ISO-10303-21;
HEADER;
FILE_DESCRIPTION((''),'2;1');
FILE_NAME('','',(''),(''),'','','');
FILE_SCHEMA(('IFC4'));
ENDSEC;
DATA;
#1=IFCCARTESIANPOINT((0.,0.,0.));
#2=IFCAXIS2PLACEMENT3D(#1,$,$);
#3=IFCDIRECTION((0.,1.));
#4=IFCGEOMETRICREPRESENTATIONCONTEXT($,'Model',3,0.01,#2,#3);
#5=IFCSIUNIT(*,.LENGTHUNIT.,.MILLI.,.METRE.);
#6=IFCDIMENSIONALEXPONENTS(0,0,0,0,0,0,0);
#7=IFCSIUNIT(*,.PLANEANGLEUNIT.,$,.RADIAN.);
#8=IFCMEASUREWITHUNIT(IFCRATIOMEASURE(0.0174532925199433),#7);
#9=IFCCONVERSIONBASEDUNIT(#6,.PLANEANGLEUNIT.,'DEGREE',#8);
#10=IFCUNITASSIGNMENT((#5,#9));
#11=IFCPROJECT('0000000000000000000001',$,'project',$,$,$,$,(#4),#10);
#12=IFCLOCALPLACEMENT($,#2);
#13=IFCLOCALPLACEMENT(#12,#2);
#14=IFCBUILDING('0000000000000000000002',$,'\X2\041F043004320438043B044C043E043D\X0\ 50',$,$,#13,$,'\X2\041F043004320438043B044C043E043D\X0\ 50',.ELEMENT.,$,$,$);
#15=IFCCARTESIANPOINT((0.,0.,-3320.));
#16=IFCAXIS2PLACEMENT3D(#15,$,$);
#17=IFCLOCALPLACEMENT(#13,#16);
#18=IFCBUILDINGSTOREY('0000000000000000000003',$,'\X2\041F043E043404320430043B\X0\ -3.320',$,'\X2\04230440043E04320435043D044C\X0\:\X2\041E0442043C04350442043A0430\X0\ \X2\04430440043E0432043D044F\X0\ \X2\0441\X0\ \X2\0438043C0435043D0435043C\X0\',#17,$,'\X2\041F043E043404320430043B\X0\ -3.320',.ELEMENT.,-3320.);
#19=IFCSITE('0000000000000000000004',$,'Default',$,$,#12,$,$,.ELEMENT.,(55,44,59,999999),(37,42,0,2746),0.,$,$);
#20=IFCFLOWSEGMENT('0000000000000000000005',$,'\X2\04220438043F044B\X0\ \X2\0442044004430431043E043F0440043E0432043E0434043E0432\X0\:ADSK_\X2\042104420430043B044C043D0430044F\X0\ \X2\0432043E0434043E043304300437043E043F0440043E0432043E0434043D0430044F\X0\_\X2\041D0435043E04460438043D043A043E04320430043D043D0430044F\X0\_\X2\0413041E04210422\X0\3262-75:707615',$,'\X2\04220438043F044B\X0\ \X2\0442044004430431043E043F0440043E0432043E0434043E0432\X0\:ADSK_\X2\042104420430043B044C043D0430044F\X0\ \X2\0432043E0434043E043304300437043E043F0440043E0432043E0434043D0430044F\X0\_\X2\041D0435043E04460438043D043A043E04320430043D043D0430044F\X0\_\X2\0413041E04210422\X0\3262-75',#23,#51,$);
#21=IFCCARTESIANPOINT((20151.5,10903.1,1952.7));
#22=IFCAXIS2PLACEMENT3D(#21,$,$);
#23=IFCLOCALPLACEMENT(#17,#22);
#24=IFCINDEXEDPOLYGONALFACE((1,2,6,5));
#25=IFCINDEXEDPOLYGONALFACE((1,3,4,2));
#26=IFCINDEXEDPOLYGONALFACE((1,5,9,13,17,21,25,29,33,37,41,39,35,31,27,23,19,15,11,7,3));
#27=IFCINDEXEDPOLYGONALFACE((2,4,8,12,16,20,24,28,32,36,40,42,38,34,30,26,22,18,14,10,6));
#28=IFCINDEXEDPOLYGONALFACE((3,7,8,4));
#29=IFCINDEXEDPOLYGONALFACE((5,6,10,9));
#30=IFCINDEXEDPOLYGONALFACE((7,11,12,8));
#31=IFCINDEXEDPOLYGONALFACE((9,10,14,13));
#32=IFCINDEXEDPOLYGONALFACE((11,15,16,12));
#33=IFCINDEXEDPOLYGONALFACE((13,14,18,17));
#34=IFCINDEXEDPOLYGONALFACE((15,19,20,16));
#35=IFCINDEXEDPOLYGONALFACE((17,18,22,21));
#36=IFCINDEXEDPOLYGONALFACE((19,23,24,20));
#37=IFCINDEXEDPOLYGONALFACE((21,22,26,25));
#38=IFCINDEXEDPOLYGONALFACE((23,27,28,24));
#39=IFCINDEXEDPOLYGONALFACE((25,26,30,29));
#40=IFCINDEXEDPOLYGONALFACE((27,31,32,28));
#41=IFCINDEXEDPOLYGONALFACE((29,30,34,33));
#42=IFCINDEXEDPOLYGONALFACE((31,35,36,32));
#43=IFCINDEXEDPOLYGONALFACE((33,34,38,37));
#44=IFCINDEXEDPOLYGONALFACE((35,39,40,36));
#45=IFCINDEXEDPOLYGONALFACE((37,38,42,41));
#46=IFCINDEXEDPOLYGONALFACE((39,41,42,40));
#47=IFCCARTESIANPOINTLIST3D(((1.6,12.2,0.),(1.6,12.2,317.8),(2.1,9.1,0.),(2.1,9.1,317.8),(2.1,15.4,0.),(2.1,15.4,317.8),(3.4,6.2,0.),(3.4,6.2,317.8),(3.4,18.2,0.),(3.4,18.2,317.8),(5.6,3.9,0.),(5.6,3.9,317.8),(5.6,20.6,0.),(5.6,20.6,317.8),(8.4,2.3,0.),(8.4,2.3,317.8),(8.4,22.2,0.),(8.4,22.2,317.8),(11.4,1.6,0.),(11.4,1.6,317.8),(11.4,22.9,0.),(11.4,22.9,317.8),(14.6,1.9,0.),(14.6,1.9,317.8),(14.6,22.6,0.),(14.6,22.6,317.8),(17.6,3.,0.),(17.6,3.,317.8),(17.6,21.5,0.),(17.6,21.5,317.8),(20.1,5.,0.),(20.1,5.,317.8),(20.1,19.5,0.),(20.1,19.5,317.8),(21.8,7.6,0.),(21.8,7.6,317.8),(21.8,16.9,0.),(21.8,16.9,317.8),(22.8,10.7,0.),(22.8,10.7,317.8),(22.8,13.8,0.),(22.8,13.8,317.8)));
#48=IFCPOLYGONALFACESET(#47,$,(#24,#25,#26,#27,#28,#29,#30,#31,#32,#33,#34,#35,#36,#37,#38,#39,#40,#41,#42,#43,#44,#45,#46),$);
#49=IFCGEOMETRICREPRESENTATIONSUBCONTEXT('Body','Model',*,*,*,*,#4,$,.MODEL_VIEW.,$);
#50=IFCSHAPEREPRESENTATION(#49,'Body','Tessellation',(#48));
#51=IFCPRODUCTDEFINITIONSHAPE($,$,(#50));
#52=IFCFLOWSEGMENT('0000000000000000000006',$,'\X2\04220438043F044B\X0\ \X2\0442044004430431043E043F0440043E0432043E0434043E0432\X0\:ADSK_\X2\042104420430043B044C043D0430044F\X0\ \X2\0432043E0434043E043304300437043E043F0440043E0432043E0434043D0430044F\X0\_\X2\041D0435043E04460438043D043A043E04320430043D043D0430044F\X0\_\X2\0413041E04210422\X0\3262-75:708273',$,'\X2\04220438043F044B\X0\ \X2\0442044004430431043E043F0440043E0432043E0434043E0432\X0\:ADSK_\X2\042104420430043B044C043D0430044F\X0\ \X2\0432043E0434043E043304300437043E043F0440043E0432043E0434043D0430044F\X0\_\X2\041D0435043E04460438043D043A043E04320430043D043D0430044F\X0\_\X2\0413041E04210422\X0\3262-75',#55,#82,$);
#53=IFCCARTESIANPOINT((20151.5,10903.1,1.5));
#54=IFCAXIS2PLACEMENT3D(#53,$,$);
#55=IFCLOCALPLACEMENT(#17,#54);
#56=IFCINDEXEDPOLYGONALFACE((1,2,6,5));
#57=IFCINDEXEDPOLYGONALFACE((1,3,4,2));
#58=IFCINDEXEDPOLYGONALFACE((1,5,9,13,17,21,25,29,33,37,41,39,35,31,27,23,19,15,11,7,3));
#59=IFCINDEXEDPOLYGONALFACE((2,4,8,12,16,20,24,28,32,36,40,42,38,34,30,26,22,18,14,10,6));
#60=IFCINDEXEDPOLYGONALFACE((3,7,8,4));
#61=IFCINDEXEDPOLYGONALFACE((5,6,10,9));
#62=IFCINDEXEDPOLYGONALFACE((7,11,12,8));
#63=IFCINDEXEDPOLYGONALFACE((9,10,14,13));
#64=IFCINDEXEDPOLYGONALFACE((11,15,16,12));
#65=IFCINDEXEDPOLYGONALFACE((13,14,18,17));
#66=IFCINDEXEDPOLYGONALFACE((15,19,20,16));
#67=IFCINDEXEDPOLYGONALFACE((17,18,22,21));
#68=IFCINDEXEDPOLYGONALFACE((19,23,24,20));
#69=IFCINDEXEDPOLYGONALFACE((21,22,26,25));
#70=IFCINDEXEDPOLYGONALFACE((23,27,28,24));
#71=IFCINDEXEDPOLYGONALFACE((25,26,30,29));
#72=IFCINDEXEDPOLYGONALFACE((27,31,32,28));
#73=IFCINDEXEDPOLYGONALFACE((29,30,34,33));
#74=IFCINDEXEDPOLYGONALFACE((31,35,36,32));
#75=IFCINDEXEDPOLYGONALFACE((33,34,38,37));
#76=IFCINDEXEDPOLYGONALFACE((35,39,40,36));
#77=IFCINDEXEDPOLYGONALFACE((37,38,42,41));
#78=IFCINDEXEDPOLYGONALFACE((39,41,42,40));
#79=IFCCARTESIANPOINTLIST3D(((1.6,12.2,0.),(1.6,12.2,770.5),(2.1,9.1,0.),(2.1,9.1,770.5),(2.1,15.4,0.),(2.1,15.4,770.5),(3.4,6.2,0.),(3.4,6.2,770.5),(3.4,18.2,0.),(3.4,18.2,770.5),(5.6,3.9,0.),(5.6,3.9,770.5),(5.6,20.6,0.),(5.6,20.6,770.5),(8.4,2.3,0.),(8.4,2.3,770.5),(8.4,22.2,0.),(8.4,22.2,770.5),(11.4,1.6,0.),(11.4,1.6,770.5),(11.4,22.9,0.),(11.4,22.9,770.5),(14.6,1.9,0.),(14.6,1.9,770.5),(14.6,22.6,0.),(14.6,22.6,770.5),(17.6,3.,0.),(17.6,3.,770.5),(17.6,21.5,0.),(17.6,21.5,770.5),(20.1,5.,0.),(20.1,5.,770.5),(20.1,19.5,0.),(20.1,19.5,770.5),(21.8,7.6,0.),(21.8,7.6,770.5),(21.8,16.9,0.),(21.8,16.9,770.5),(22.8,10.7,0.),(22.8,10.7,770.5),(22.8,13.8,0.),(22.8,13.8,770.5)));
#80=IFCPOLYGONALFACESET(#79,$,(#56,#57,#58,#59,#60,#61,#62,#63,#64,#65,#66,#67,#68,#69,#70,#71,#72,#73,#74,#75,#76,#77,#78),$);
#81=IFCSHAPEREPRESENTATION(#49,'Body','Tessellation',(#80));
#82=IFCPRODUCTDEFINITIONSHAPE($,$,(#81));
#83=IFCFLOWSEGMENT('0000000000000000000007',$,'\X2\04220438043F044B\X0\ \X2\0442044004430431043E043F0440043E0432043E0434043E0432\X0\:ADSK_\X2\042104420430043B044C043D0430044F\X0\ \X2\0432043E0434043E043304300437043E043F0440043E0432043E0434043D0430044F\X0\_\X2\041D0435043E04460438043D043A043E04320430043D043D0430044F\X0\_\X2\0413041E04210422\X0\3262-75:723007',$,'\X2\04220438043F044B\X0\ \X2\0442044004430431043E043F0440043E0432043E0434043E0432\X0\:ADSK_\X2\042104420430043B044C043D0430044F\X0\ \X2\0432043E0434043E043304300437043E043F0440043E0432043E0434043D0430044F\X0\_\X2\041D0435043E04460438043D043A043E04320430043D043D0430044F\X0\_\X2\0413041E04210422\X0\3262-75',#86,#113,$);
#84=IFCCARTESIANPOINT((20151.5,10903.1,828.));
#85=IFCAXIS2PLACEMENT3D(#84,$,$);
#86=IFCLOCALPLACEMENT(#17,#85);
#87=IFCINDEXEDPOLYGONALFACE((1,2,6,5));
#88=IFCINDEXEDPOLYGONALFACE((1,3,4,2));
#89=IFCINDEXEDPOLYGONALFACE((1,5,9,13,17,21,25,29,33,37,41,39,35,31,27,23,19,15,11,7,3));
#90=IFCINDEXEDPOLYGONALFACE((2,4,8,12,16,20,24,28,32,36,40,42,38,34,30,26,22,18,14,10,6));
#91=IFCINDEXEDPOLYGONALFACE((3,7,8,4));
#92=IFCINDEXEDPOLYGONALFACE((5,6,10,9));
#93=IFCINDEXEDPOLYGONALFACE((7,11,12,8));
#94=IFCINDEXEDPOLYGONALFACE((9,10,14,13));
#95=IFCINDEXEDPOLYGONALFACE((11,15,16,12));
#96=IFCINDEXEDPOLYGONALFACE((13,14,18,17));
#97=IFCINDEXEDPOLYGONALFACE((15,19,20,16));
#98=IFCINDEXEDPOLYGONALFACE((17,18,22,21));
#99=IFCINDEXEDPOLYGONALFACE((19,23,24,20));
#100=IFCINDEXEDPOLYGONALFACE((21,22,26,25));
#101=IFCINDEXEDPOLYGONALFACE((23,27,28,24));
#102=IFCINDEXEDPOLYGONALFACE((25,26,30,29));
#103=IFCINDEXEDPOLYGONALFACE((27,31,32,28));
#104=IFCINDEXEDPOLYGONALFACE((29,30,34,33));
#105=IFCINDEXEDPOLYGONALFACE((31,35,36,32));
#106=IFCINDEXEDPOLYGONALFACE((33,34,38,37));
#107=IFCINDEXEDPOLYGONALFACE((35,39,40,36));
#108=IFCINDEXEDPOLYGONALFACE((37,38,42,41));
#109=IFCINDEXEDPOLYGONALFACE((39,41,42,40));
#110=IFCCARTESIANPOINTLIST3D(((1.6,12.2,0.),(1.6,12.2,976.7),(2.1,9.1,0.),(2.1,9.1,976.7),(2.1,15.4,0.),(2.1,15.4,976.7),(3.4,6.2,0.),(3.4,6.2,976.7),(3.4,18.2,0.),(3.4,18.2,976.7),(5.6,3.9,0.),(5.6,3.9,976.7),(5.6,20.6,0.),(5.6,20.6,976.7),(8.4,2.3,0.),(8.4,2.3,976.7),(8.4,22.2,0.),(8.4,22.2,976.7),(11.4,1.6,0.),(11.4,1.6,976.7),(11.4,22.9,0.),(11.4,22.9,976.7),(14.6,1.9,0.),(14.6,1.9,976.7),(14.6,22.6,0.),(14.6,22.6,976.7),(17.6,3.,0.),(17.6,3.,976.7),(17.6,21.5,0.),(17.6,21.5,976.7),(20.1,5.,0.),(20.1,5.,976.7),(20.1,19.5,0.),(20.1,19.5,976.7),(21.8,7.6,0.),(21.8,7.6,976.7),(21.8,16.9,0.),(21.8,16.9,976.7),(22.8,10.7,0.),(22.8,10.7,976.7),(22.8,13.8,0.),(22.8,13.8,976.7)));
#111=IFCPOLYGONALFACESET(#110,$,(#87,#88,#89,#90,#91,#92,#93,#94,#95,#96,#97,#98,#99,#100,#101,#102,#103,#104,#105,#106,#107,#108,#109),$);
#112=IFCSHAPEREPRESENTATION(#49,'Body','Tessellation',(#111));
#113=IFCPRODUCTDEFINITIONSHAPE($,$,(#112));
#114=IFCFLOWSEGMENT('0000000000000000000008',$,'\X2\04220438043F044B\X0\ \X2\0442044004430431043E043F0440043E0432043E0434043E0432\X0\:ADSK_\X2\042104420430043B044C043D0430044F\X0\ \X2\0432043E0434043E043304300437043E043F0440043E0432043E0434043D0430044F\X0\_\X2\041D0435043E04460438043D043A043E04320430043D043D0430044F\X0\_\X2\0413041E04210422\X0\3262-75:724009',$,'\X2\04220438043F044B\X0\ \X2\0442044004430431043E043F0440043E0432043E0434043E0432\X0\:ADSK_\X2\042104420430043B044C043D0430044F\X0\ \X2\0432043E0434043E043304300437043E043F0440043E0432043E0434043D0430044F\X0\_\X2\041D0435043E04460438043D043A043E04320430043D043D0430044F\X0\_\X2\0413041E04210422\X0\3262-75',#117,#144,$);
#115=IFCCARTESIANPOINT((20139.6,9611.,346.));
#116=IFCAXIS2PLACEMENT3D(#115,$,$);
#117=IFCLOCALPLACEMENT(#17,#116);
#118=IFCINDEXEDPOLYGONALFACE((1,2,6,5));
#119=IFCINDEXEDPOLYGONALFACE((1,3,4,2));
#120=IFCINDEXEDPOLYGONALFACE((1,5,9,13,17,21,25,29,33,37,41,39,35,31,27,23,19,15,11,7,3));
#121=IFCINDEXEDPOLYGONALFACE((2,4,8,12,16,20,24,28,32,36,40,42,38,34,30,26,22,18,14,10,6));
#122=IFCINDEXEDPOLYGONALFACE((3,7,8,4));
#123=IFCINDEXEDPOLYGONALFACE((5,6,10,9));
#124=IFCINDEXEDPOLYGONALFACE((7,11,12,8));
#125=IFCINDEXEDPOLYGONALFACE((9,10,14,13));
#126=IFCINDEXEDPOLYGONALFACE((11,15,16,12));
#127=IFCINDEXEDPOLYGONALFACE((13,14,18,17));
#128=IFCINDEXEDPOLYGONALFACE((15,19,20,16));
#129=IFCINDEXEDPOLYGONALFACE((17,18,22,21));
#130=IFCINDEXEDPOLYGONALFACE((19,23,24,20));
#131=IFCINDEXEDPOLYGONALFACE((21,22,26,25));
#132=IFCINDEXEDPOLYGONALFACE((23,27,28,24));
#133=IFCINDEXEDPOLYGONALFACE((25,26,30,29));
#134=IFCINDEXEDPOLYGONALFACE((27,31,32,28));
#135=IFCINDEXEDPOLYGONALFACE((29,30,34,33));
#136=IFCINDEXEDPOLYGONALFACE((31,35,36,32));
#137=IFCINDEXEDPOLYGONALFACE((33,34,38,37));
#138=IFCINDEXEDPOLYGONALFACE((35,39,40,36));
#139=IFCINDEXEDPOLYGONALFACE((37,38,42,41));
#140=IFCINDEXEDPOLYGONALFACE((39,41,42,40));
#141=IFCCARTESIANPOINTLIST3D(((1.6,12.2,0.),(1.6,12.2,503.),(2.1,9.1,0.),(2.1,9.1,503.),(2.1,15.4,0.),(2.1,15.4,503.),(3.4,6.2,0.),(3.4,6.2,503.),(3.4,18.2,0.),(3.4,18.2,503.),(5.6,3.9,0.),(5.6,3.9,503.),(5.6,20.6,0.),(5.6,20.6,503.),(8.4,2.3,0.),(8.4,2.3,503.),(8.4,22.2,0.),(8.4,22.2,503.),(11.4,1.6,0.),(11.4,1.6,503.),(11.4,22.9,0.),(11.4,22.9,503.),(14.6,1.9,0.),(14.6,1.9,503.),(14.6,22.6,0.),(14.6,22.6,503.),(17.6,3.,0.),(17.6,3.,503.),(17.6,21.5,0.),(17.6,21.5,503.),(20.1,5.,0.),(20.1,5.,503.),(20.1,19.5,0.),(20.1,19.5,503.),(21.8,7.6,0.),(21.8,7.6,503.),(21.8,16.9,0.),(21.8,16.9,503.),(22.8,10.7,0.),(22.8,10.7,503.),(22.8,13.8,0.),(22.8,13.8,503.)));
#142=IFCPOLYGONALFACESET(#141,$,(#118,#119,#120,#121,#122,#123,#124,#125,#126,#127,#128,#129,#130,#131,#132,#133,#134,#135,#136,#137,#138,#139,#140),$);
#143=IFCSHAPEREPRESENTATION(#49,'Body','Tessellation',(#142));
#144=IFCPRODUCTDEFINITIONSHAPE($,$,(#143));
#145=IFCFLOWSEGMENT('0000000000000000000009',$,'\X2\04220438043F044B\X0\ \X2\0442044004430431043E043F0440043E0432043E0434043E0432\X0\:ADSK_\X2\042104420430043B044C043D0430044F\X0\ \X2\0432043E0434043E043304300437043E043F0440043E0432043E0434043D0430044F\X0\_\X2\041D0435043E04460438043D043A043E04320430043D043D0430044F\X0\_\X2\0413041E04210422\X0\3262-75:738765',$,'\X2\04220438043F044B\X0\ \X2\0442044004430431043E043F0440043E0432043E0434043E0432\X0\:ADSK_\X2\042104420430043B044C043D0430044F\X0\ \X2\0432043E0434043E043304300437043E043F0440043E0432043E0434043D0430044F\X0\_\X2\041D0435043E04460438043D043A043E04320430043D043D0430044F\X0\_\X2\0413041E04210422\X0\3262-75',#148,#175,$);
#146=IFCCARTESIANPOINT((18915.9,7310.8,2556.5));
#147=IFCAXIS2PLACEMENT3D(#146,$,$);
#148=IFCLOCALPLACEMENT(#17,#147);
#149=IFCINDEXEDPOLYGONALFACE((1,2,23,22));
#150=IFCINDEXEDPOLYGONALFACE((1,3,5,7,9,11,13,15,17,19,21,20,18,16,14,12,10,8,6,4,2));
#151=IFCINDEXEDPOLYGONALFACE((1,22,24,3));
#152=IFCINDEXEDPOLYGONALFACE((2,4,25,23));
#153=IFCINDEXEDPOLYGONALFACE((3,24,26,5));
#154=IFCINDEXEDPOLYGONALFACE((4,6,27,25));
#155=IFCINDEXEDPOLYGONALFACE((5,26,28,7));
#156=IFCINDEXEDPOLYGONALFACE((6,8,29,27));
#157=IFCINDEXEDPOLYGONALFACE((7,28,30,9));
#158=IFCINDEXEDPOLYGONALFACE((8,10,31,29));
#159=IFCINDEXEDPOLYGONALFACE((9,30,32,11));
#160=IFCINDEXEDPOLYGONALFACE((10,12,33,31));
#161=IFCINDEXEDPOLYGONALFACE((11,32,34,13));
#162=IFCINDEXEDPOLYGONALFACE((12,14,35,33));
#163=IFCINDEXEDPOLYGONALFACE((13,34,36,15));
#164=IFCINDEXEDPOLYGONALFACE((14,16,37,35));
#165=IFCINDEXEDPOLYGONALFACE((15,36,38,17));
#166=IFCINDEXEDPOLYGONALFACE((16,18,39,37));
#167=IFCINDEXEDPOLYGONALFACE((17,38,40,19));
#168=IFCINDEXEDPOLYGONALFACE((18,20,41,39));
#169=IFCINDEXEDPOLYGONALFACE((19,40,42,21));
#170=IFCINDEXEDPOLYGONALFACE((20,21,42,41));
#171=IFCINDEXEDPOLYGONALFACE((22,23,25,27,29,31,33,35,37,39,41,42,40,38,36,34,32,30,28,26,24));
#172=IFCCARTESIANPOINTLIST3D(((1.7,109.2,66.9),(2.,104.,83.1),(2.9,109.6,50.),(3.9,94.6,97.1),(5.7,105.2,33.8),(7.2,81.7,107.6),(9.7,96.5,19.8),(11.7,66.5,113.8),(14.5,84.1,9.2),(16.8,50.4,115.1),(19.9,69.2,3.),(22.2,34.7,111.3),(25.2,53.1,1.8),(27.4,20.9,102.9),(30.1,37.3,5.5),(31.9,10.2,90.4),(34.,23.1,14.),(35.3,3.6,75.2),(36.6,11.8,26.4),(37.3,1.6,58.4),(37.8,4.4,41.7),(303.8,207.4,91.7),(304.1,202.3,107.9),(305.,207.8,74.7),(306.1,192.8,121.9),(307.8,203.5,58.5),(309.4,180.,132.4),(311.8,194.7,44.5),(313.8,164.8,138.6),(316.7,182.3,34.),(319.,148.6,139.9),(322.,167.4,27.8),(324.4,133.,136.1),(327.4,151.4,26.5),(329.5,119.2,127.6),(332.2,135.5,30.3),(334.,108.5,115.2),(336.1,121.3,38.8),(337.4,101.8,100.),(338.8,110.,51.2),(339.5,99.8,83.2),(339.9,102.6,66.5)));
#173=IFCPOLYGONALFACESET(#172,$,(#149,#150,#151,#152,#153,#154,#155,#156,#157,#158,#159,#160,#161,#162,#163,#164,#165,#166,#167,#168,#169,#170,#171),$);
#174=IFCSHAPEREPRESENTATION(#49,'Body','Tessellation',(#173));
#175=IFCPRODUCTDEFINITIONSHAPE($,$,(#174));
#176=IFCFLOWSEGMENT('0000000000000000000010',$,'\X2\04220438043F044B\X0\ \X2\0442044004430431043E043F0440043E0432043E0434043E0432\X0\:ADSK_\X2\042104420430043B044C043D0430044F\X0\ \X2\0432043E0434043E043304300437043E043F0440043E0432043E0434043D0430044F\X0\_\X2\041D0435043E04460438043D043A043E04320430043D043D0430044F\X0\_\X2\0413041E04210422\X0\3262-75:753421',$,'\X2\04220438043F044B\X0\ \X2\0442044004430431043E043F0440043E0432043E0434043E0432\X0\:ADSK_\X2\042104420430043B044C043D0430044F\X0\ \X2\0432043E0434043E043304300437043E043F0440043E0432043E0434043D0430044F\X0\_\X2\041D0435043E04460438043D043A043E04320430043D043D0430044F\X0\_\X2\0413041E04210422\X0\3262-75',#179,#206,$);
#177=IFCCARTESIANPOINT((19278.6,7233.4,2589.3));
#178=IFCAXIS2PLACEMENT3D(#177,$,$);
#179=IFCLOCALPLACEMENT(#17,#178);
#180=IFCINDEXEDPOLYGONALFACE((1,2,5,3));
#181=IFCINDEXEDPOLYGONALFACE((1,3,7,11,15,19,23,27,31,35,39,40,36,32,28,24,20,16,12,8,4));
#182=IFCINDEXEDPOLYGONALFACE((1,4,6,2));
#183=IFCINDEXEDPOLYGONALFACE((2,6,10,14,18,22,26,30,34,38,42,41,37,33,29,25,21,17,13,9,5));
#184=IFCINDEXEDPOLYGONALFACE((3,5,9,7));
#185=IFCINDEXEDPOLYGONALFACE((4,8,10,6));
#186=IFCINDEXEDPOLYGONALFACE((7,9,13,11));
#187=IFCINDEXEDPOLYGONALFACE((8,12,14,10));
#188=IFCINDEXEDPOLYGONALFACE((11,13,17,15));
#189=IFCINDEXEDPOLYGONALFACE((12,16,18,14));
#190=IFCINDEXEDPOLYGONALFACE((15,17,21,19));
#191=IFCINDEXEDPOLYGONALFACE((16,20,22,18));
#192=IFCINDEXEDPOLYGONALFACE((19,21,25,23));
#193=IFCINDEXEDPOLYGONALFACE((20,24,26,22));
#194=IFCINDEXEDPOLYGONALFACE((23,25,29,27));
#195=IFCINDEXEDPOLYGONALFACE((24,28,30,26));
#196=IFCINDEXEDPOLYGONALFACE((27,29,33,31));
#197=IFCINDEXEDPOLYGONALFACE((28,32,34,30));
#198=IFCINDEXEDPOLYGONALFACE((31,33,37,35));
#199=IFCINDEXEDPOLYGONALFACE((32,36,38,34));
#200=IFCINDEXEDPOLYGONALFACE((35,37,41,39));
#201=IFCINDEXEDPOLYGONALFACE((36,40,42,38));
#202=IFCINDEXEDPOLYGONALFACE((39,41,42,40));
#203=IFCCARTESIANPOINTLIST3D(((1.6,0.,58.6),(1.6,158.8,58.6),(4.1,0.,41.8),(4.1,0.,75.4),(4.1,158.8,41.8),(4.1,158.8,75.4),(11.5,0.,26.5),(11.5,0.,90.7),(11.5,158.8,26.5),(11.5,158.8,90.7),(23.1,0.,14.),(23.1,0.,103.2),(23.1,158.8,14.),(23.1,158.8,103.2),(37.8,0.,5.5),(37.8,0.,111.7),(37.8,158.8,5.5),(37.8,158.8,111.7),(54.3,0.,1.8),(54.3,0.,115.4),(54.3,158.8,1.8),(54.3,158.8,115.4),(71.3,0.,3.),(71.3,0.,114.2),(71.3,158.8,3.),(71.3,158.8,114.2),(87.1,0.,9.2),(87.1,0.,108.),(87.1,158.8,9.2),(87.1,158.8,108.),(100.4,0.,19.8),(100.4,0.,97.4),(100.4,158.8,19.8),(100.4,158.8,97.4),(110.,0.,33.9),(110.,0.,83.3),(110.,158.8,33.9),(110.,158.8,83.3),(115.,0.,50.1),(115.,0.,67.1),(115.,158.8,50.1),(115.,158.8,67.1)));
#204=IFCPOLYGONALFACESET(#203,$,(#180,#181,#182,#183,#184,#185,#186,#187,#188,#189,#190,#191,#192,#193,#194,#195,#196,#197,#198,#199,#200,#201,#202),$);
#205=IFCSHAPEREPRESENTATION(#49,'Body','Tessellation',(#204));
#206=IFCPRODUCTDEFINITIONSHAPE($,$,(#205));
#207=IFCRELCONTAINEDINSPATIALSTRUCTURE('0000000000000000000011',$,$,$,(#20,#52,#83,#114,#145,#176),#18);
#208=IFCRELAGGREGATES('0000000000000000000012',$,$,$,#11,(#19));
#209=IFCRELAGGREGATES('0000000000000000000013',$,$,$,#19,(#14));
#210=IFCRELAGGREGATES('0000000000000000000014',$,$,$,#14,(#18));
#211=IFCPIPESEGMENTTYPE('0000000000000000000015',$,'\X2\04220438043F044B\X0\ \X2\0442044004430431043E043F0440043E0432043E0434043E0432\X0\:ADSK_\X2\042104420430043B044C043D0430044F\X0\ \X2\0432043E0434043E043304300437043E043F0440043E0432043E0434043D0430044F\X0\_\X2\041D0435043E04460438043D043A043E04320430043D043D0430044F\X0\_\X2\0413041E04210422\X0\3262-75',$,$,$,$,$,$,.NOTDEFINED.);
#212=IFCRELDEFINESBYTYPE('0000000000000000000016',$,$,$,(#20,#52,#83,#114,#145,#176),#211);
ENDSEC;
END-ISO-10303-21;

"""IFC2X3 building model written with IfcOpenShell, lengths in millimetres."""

from ifc_helpers import new_model, entity, si_unit, converted_unit, direction, frame, frame_2d, origin, origin_2d_with_axis, place, context, subcontext, project, spatial, circle, extrude, type_object, element, save


model = new_model("IFC2X3")

# Units and contexts
model_context = context("Model", 3, precision=0.01, world=origin(), true_north=direction((0.0, 1.0)))
body_context = subcontext(model_context, "Body", "Model", "MODEL_VIEW")
ifc_project = project(units=[si_unit("LENGTHUNIT", "METRE", prefix="MILLI"), converted_unit("PLANEANGLEUNIT", "DEGREE", entity("IfcRatioMeasure", 0.0174532925199433), si_unit("PLANEANGLEUNIT", "RADIAN"), dimensions=[0, 0, 0, 0, 0, 0, 0])], contexts=[model_context])

# Site, building, storey
site_placement = place(None, origin())
site = spatial("IfcSite", under=ifc_project, at=site_placement, Name="Default", CompositionType="ELEMENT", RefLatitude=(55, 44, 59, 999999), RefLongitude=(37, 42, 0, 2746), RefElevation=0.0)
building_placement = place(site_placement, origin())
building = spatial("IfcBuilding", under=site, at=building_placement, Name="Павильон 50", LongName="Павильон 50", CompositionType="ELEMENT")
storey_placement = place(building_placement, frame((0.0, 0.0, -3320.0)))
storey = spatial("IfcBuildingStorey", under=building, at=storey_placement, Name="Подвал -3.320", ObjectType="Уровень:Отметка уровня с именем", LongName="Подвал -3.320", CompositionType="ELEMENT", Elevation=-3320.0)

# Flow segments
pipe_segment_type = type_object("IfcPipeSegmentType", Name="Типы трубопроводов:ADSK_Стальная водогазопроводная_Неоцинкованная_ГОСТ3262-75", PredefinedType="NOTDEFINED")
flow_segment_1_placement = place(storey_placement, frame((20151.5, 10903.1, 1952.7)))
element("IfcFlowSegment", 1, at=flow_segment_1_placement, inside=storey, type_object=pipe_segment_type, Name="Типы трубопроводов:ADSK_Стальная водогазопроводная_Неоцинкованная_ГОСТ3262-75:707615", ObjectType="Типы трубопроводов:ADSK_Стальная водогазопроводная_Неоцинкованная_ГОСТ3262-75", context=body_context, shape_type="SweptSolid", body=[
    extrude(circle(Radius=10.7, at=origin_2d_with_axis()), frame((12.2, 12.2, 0.0), z_axis=(0.0, 0.0, 1.0), x_axis=(-1.0, 0.0, 0.0)), (0.0, 0.0, 1.0), 317.8),
])
flow_segment_2_placement = place(storey_placement, frame((20151.5, 10903.1, 1.5)))
element("IfcFlowSegment", 2, at=flow_segment_2_placement, inside=storey, type_object=pipe_segment_type, Name="Типы трубопроводов:ADSK_Стальная водогазопроводная_Неоцинкованная_ГОСТ3262-75:708273", ObjectType="Типы трубопроводов:ADSK_Стальная водогазопроводная_Неоцинкованная_ГОСТ3262-75", context=body_context, shape_type="SweptSolid", body=[
    extrude(circle(Radius=10.7, at=origin_2d_with_axis()), frame((12.2, 12.2, 0.0), z_axis=(0.0, 0.0, 1.0), x_axis=(-1.0, 0.0, 0.0)), (0.0, 0.0, 1.0), 770.5),
])
flow_segment_3_placement = place(storey_placement, frame((20151.5, 10903.1, 828.0)))
element("IfcFlowSegment", 3, at=flow_segment_3_placement, inside=storey, type_object=pipe_segment_type, Name="Типы трубопроводов:ADSK_Стальная водогазопроводная_Неоцинкованная_ГОСТ3262-75:723007", ObjectType="Типы трубопроводов:ADSK_Стальная водогазопроводная_Неоцинкованная_ГОСТ3262-75", context=body_context, shape_type="SweptSolid", body=[
    extrude(circle(Radius=10.7, at=origin_2d_with_axis()), frame((12.2, 12.2, 0.0), z_axis=(0.0, 0.0, 1.0), x_axis=(-1.0, 0.0, 0.0)), (0.0, 0.0, 1.0), 976.7),
])
flow_segment_4_placement = place(storey_placement, frame((20139.6, 9611.0, 346.0)))
element("IfcFlowSegment", 4, at=flow_segment_4_placement, inside=storey, type_object=pipe_segment_type, Name="Типы трубопроводов:ADSK_Стальная водогазопроводная_Неоцинкованная_ГОСТ3262-75:724009", ObjectType="Типы трубопроводов:ADSK_Стальная водогазопроводная_Неоцинкованная_ГОСТ3262-75", context=body_context, shape_type="SweptSolid", body=[
    extrude(circle(Radius=10.7, at=origin_2d_with_axis()), frame((12.2, 12.2, 0.0), z_axis=(0.0, 0.0, 1.0), x_axis=(-1.0, 0.0, 0.0)), (0.0, 0.0, 1.0), 503.0),
])
flow_segment_5_placement = place(storey_placement, frame((18915.9, 7310.8, 2556.5)))
element("IfcFlowSegment", 5, at=flow_segment_5_placement, inside=storey, type_object=pipe_segment_type, Name="Типы трубопроводов:ADSK_Стальная водогазопроводная_Неоцинкованная_ГОСТ3262-75:738765", ObjectType="Типы трубопроводов:ADSK_Стальная водогазопроводная_Неоцинкованная_ГОСТ3262-75", context=body_context, shape_type="SweptSolid", body=[
    extrude(circle(Radius=57.0, at=frame_2d((0.0, 0.0), x_axis=(1.0, 0.0))), frame((19.7, 55.8, 58.4), z_axis=(0.948111, 0.308285, 0.077758), x_axis=(0.309221, -0.95099, 0.0)), (0.0, 0.0, 1.0), 318.7),
])
flow_segment_6_placement = place(storey_placement, frame((19278.6, 7233.4, 2589.3)))
element("IfcFlowSegment", 6, at=flow_segment_6_placement, inside=storey, type_object=pipe_segment_type, Name="Типы трубопроводов:ADSK_Стальная водогазопроводная_Неоцинкованная_ГОСТ3262-75:753421", ObjectType="Типы трубопроводов:ADSK_Стальная водогазопроводная_Неоцинкованная_ГОСТ3262-75", context=body_context, shape_type="SweptSolid", body=[
    extrude(circle(Radius=57.0, at=origin_2d_with_axis()), frame((58.6, 0.0, 58.6), z_axis=(0.0, 1.0, 0.0), x_axis=(-1.0, 0.0, 0.0)), (0.0, 0.0, 1.0), 158.8),
])

save(model, "model.ifc")
